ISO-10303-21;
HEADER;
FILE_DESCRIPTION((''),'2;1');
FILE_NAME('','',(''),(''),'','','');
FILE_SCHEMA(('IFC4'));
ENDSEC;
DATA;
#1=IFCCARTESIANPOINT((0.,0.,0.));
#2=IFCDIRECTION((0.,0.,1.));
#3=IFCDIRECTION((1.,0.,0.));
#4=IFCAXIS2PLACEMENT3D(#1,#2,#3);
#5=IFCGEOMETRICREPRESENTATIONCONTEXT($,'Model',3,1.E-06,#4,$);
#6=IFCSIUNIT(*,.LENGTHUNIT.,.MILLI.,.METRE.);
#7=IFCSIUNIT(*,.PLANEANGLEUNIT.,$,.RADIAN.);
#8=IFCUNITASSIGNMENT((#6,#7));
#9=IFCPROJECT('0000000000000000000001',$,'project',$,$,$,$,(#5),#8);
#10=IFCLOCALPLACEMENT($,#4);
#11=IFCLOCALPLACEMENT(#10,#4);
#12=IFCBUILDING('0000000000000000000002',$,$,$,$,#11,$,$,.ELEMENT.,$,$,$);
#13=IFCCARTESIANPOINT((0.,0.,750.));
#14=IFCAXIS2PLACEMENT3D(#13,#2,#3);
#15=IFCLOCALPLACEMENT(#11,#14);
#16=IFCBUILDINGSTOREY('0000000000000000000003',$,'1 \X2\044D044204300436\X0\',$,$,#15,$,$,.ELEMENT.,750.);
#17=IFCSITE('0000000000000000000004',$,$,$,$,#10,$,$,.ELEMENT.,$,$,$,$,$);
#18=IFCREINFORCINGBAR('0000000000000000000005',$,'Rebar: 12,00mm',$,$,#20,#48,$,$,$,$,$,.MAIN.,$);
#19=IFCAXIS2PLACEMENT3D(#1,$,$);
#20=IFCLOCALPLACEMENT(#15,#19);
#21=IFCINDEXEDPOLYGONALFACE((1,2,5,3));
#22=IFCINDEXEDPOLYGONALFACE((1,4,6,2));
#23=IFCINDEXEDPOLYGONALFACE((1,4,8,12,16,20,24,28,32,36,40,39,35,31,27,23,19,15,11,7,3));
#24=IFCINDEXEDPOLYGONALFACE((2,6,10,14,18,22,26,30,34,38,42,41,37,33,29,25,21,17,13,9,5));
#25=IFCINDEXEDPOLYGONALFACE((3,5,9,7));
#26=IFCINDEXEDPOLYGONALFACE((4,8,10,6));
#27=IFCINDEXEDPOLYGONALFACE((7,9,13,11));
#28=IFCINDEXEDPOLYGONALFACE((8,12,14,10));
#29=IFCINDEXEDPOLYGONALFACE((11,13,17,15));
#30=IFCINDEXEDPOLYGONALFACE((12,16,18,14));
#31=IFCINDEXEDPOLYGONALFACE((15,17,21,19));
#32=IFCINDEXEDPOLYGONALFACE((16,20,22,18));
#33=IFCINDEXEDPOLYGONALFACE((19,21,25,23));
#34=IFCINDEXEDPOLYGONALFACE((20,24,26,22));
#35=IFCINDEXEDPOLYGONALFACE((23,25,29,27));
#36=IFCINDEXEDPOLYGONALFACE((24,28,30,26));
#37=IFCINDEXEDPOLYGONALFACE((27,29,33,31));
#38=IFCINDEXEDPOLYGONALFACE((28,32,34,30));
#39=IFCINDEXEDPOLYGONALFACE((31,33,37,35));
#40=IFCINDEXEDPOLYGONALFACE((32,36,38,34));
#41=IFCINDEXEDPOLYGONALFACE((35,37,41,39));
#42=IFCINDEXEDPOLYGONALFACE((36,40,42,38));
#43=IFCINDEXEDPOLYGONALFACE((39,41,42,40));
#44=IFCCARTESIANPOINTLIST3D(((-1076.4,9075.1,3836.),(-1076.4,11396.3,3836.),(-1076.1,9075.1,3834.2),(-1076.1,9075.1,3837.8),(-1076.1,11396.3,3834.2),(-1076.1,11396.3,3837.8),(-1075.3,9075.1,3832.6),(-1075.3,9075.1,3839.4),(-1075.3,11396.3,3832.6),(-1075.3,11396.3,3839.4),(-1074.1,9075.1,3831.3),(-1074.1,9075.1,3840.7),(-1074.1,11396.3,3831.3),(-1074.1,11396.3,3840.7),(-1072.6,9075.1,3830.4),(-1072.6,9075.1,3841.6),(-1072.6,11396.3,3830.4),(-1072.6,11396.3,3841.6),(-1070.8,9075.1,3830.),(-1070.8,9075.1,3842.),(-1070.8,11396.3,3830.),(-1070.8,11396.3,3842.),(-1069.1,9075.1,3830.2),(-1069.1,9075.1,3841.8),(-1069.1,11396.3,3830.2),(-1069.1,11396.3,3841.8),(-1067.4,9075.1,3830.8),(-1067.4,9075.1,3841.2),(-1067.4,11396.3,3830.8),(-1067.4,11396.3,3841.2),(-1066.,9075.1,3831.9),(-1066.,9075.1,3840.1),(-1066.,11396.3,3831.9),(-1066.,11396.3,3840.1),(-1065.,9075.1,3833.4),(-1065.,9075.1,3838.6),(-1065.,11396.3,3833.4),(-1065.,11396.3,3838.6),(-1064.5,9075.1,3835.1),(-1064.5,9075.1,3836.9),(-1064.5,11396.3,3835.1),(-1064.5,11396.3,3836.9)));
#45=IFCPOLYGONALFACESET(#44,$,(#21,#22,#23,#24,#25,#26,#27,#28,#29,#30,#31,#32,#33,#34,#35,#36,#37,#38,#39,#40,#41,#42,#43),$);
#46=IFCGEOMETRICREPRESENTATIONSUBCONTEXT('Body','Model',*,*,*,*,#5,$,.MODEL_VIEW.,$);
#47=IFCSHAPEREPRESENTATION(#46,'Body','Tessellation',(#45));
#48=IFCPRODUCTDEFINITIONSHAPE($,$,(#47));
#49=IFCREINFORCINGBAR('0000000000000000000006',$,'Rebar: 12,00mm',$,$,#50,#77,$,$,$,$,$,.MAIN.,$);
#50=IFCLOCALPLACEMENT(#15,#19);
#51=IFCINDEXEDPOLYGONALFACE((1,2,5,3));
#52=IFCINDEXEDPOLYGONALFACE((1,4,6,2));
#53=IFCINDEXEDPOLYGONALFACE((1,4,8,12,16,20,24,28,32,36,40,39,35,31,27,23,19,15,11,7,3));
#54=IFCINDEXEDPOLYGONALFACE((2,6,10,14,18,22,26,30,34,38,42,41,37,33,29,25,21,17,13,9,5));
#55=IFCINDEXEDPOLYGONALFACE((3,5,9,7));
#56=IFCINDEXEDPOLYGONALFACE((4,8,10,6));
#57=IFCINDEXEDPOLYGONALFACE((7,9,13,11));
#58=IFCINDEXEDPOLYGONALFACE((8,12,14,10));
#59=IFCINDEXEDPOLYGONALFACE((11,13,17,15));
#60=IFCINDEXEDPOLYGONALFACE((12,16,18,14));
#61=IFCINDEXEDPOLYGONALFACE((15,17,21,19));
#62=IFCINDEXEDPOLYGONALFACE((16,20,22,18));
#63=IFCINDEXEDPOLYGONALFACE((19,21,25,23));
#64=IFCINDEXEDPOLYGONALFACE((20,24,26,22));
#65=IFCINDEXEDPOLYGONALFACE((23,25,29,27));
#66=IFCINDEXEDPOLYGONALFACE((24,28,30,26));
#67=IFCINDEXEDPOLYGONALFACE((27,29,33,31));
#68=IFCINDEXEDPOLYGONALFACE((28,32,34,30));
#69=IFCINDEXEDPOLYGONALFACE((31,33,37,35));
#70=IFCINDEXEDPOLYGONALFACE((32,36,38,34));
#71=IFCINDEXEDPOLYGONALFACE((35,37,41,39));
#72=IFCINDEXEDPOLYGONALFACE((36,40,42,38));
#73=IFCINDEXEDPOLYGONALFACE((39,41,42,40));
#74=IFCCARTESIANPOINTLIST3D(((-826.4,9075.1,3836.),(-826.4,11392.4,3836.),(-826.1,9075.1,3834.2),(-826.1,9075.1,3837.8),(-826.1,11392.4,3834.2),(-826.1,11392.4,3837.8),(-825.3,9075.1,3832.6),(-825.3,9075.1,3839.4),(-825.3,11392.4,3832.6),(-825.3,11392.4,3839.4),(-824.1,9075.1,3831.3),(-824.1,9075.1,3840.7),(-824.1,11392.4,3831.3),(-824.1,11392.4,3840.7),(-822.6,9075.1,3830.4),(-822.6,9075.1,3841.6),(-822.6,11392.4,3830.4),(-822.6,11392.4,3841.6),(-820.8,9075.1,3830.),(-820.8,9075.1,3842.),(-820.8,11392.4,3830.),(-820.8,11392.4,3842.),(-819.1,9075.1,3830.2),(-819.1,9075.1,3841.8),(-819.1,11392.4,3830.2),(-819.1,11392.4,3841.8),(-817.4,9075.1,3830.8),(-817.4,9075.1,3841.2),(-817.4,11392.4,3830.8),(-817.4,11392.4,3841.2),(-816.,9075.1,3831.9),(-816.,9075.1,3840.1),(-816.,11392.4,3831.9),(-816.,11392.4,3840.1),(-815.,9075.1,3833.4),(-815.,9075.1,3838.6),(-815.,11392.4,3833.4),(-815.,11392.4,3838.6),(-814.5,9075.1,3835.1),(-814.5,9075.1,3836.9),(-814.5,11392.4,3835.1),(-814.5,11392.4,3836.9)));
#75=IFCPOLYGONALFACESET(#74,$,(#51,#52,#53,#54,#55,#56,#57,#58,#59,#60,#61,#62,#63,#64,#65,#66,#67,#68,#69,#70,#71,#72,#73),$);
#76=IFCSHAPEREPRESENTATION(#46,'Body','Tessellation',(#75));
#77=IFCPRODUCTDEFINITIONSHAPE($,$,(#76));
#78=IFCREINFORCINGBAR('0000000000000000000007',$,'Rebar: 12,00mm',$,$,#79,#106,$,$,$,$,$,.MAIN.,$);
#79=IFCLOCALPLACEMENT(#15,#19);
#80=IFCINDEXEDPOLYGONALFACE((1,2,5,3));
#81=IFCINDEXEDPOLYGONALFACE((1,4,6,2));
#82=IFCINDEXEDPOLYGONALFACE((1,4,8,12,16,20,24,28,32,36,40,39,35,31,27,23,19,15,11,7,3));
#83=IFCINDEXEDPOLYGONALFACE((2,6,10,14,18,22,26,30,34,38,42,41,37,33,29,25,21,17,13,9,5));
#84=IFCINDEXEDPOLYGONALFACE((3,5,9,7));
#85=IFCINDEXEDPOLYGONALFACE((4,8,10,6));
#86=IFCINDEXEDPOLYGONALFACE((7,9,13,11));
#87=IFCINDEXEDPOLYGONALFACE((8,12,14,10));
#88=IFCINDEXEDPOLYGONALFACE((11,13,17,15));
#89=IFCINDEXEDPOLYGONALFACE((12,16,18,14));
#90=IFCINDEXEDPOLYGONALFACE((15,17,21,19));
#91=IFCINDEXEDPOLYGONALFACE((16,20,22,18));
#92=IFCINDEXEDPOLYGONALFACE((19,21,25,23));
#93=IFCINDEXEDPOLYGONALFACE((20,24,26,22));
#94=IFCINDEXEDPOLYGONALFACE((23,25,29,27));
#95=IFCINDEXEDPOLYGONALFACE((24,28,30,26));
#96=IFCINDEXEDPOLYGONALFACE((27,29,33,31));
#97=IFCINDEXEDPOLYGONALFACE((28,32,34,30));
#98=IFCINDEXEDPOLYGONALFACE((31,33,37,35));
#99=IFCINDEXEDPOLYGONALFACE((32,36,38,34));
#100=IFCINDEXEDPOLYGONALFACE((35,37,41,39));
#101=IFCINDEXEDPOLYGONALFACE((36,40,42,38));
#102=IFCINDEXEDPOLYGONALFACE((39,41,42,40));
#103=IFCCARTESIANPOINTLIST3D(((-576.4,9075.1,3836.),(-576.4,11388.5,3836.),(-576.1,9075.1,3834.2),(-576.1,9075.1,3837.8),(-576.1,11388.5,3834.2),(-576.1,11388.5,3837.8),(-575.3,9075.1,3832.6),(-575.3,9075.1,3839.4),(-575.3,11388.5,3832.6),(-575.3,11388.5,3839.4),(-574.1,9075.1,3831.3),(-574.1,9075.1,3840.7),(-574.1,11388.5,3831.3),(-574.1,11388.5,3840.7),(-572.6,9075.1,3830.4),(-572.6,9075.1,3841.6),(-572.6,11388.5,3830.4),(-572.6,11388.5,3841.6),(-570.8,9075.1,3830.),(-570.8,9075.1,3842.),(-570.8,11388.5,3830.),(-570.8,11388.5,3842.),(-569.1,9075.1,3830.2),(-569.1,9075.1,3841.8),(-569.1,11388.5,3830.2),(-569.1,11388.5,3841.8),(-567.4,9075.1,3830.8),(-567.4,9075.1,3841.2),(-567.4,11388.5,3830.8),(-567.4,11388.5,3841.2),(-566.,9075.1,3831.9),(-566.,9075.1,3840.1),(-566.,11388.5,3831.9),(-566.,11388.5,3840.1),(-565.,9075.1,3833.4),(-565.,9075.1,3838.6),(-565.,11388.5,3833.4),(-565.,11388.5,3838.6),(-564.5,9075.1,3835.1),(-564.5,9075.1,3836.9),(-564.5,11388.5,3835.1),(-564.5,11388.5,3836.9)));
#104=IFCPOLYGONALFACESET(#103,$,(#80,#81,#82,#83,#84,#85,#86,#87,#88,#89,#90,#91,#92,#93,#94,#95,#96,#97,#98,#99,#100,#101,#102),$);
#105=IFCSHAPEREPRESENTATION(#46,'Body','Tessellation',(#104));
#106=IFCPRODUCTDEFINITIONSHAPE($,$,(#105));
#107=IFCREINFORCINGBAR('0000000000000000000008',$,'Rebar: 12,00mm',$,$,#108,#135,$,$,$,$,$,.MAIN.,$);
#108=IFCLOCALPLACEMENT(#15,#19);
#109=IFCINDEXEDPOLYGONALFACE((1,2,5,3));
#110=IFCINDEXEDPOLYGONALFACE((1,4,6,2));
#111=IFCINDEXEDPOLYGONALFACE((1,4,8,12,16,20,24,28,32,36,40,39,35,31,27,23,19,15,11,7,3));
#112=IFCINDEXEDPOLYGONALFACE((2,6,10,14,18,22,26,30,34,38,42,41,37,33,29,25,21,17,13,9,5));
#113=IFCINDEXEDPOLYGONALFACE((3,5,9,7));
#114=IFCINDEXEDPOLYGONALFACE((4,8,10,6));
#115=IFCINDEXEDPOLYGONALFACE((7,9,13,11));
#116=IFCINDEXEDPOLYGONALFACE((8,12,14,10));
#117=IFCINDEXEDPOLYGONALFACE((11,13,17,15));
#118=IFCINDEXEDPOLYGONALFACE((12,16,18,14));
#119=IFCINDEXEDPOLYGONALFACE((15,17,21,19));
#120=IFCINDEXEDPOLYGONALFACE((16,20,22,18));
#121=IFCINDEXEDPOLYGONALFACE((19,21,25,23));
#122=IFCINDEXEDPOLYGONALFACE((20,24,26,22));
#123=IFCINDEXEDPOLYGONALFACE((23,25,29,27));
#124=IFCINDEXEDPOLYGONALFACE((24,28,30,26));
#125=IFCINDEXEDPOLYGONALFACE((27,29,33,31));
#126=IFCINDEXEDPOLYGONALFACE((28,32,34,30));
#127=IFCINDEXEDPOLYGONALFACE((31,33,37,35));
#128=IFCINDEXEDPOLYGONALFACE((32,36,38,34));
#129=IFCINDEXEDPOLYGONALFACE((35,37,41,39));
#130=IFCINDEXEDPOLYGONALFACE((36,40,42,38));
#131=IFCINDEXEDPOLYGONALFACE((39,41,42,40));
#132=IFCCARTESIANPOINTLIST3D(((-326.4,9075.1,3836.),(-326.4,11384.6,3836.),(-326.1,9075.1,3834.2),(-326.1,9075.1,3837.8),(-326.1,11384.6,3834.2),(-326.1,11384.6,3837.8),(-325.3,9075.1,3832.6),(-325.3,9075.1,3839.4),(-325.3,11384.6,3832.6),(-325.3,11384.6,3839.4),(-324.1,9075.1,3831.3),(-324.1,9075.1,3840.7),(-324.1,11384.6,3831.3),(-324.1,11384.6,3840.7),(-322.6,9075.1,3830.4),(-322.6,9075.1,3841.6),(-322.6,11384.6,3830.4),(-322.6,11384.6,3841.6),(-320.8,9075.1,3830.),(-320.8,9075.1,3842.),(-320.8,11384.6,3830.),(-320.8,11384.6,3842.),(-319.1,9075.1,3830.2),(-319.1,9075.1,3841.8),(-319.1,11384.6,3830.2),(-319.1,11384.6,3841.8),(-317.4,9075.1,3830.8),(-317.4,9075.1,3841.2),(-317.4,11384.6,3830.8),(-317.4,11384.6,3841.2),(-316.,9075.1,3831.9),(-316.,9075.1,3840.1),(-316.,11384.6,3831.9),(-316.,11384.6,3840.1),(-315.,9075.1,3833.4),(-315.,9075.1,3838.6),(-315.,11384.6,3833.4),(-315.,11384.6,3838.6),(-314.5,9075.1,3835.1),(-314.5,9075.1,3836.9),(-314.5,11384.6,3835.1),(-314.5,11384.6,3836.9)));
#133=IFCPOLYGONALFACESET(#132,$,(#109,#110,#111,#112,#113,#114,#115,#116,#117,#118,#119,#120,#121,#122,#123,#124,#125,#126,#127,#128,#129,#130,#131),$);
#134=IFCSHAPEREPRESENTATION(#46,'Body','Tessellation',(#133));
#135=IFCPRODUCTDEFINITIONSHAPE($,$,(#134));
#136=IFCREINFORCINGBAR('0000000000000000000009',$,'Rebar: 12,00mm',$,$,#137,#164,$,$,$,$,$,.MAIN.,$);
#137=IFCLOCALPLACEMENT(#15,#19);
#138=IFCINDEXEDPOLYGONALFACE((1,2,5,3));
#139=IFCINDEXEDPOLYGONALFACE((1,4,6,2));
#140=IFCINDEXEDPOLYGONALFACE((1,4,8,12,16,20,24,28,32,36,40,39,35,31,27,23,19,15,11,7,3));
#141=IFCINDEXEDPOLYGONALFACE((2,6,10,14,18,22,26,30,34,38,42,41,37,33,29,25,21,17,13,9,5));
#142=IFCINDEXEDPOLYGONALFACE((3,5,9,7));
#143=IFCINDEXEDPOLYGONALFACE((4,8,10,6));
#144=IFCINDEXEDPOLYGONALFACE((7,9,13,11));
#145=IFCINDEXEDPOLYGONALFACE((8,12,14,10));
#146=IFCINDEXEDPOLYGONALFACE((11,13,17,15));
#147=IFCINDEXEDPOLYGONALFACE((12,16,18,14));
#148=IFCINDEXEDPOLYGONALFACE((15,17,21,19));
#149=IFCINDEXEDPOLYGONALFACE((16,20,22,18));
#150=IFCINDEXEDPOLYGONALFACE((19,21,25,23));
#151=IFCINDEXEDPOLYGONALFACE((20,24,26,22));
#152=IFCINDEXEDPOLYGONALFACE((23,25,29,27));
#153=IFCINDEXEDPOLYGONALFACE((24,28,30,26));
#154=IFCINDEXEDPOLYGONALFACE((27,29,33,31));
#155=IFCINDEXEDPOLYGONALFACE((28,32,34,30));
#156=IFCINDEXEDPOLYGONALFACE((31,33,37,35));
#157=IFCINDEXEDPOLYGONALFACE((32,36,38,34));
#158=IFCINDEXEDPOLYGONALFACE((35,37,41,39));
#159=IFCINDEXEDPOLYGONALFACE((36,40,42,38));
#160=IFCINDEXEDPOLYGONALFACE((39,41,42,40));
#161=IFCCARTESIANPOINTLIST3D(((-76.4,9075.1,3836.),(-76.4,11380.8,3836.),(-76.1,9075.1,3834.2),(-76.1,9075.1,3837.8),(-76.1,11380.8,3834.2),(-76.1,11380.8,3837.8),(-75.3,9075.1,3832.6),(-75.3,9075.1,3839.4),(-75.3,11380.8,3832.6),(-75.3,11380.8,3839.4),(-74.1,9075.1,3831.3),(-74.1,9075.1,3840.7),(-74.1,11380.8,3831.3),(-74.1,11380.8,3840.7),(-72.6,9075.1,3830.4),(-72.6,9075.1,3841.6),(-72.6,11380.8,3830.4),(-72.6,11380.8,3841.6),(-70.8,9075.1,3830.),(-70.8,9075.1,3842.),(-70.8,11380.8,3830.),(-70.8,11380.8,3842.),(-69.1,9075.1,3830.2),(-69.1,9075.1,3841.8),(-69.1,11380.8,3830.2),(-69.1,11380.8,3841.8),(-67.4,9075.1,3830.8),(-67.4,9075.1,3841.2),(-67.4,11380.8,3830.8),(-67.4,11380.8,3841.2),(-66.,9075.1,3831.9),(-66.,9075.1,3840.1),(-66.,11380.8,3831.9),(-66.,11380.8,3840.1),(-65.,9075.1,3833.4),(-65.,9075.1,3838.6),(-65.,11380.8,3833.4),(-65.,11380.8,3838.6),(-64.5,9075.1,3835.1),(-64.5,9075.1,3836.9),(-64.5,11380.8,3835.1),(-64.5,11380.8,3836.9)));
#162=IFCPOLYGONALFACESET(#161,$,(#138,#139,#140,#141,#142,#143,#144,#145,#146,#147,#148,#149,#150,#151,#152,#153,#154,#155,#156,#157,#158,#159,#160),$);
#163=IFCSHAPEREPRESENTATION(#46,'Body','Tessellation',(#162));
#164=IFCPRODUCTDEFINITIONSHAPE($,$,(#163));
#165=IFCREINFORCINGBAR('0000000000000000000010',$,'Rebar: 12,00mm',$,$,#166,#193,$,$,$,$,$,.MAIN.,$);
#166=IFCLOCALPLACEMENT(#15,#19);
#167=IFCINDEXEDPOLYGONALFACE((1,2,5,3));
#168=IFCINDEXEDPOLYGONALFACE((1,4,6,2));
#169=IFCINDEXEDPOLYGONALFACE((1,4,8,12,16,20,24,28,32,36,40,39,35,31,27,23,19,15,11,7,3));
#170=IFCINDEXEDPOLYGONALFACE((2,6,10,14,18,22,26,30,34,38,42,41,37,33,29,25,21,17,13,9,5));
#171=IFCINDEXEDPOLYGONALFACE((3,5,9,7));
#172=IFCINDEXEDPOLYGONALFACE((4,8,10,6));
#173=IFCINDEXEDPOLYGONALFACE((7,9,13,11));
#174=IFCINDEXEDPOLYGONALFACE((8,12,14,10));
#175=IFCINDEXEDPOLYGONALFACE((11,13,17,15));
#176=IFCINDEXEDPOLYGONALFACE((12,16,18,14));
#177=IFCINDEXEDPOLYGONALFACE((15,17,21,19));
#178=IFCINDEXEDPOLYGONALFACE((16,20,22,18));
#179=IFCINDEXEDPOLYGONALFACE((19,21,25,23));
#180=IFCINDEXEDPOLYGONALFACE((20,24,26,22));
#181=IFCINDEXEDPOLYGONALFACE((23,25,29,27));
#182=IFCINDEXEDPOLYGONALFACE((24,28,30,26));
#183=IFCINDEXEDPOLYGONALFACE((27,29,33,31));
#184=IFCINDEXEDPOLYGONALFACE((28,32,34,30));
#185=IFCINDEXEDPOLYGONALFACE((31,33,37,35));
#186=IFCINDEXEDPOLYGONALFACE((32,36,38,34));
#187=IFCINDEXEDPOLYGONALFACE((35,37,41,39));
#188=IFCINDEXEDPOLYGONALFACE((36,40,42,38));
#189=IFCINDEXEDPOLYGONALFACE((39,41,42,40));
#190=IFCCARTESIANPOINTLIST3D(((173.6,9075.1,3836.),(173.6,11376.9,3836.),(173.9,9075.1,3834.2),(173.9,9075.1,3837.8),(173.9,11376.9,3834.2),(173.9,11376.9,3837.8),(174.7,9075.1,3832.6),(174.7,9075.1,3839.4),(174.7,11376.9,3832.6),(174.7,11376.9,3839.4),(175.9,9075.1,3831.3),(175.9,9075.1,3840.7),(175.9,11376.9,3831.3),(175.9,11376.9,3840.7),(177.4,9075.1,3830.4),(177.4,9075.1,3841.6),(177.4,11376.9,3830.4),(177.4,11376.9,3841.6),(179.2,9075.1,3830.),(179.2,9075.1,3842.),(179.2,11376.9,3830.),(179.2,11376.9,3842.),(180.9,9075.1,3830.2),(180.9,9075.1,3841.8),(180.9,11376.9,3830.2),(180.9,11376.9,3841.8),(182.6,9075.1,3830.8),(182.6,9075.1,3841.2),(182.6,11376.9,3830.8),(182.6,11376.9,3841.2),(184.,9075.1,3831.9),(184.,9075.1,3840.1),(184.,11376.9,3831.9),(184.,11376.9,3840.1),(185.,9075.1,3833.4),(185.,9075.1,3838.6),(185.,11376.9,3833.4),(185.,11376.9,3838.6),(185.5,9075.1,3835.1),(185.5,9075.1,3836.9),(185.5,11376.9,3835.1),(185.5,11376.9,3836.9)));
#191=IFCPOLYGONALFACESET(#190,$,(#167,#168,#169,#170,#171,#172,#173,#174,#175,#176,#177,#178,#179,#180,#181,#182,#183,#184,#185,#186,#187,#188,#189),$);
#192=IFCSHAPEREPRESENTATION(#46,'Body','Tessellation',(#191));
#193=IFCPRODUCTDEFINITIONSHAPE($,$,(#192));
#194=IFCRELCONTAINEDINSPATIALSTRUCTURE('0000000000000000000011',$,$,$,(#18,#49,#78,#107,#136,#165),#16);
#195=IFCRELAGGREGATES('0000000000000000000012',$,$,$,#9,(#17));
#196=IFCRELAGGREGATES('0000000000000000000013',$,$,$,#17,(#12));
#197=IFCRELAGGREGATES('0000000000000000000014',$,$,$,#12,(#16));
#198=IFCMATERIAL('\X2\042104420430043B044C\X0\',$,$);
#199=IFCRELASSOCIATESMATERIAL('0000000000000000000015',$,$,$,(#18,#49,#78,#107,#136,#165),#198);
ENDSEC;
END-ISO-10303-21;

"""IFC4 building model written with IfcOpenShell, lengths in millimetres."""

from ifc_helpers import new_model, entity, si_unit, frame, origin_with_axes, place, context, subcontext, project, spatial, source, transform, mapped, material, element, save


model = new_model("IFC4")

# Units and contexts
model_context = context("Model", 3, precision=1e-06, world=origin_with_axes())
body_context = subcontext(model_context, "Body", "Model", "MODEL_VIEW")
ifc_project = project(units=[si_unit("LENGTHUNIT", "METRE", prefix="MILLI"), si_unit("PLANEANGLEUNIT", "RADIAN")], contexts=[model_context])

# Site, building, storey
site_placement = place(None, origin_with_axes())
site = spatial("IfcSite", under=ifc_project, at=site_placement, CompositionType="ELEMENT")
building_placement = place(site_placement, origin_with_axes())
building = spatial("IfcBuilding", under=site, at=building_placement, CompositionType="ELEMENT")
storey_placement = place(building_placement, frame((0.0, 0.0, 750.0), z_axis=(0.0, 0.0, 1.0), x_axis=(1.0, 0.0, 0.0)))
storey = spatial("IfcBuildingStorey", under=building, at=storey_placement, Name="1 этаж", CompositionType="ELEMENT", Elevation=750.0)

# Reinforcing bars
ifc_material = material(Name="Сталь")
shared_shape_1 = source(origin_with_axes(), body_context, "Body", "AdvancedSweptSolid", [
    entity("IfcSweptDiskSolid", entity("IfcIndexedPolyCurve", entity("IfcCartesianPointList3D", [[0.0, 0.0, 0.0], [2321.1, 0.0, 0.0]]), [entity("IfcLineIndex", [1, 2])]), 6.0),
])
reinforcing_bar_1_placement = place(storey_placement, origin_with_axes())
element("IfcReinforcingBar", 1, at=reinforcing_bar_1_placement, inside=storey, material=ifc_material, Name="Rebar: 12,00mm", PredefinedType="MAIN", context=body_context, shape_type="MappedRepresentation", body=[
    mapped(shared_shape_1, transform((-1070.4, 9075.1, 3836.0), x_axis=(0.0, 1.0, 0.0), y_axis=(-1.0, 0.0, 0.0), z_axis=(0.0, 0.0, 1.0), scale=1.0)),
])
shared_shape_2 = source(origin_with_axes(), body_context, "Body", "AdvancedSweptSolid", [
    entity("IfcSweptDiskSolid", entity("IfcIndexedPolyCurve", entity("IfcCartesianPointList3D", [[0.0, 0.0, 0.0], [2317.3, 0.0, 0.0]]), [entity("IfcLineIndex", [1, 2])]), 6.0),
])
reinforcing_bar_2_placement = place(storey_placement, origin_with_axes())
element("IfcReinforcingBar", 2, at=reinforcing_bar_2_placement, inside=storey, material=ifc_material, Name="Rebar: 12,00mm", PredefinedType="MAIN", context=body_context, shape_type="MappedRepresentation", body=[
    mapped(shared_shape_2, transform((-820.4, 9075.1, 3836.0), x_axis=(0.0, 1.0, 0.0), y_axis=(-1.0, 0.0, 0.0), z_axis=(0.0, 0.0, 1.0), scale=1.0)),
])
shared_shape_3 = source(origin_with_axes(), body_context, "Body", "AdvancedSweptSolid", [
    entity("IfcSweptDiskSolid", entity("IfcIndexedPolyCurve", entity("IfcCartesianPointList3D", [[0.0, 0.0, 0.0], [2313.4, 0.0, 0.0]]), [entity("IfcLineIndex", [1, 2])]), 6.0),
])
reinforcing_bar_3_placement = place(storey_placement, origin_with_axes())
element("IfcReinforcingBar", 3, at=reinforcing_bar_3_placement, inside=storey, material=ifc_material, Name="Rebar: 12,00mm", PredefinedType="MAIN", context=body_context, shape_type="MappedRepresentation", body=[
    mapped(shared_shape_3, transform((-570.4, 9075.1, 3836.0), x_axis=(0.0, 1.0, 0.0), y_axis=(-1.0, 0.0, 0.0), z_axis=(0.0, 0.0, 1.0), scale=1.0)),
])
shared_shape_4 = source(origin_with_axes(), body_context, "Body", "AdvancedSweptSolid", [
    entity("IfcSweptDiskSolid", entity("IfcIndexedPolyCurve", entity("IfcCartesianPointList3D", [[0.0, 0.0, 0.0], [2309.5, 0.0, 0.0]]), [entity("IfcLineIndex", [1, 2])]), 6.0),
])
reinforcing_bar_4_placement = place(storey_placement, origin_with_axes())
element("IfcReinforcingBar", 4, at=reinforcing_bar_4_placement, inside=storey, material=ifc_material, Name="Rebar: 12,00mm", PredefinedType="MAIN", context=body_context, shape_type="MappedRepresentation", body=[
    mapped(shared_shape_4, transform((-320.4, 9075.1, 3836.0), x_axis=(0.0, 1.0, 0.0), y_axis=(-1.0, 0.0, 0.0), z_axis=(0.0, 0.0, 1.0), scale=1.0)),
])
shared_shape_5 = source(origin_with_axes(), body_context, "Body", "AdvancedSweptSolid", [
    entity("IfcSweptDiskSolid", entity("IfcIndexedPolyCurve", entity("IfcCartesianPointList3D", [[0.0, 0.0, 0.0], [2305.6, 0.0, 0.0]]), [entity("IfcLineIndex", [1, 2])]), 6.0),
])
reinforcing_bar_5_placement = place(storey_placement, origin_with_axes())
element("IfcReinforcingBar", 5, at=reinforcing_bar_5_placement, inside=storey, material=ifc_material, Name="Rebar: 12,00mm", PredefinedType="MAIN", context=body_context, shape_type="MappedRepresentation", body=[
    mapped(shared_shape_5, transform((-70.4, 9075.1, 3836.0), x_axis=(0.0, 1.0, 0.0), y_axis=(-1.0, 0.0, 0.0), z_axis=(0.0, 0.0, 1.0), scale=1.0)),
])
shared_shape_6 = source(origin_with_axes(), body_context, "Body", "AdvancedSweptSolid", [
    entity("IfcSweptDiskSolid", entity("IfcIndexedPolyCurve", entity("IfcCartesianPointList3D", [[0.0, 0.0, 0.0], [2301.8, 0.0, 0.0]]), [entity("IfcLineIndex", [1, 2])]), 6.0),
])
reinforcing_bar_6_placement = place(storey_placement, origin_with_axes())
element("IfcReinforcingBar", 6, at=reinforcing_bar_6_placement, inside=storey, material=ifc_material, Name="Rebar: 12,00mm", PredefinedType="MAIN", context=body_context, shape_type="MappedRepresentation", body=[
    mapped(shared_shape_6, transform((179.6, 9075.1, 3836.0), x_axis=(0.0, 1.0, 0.0), y_axis=(-1.0, 0.0, 0.0), z_axis=(0.0, 0.0, 1.0), scale=1.0)),
])

save(model, "model.ifc")
